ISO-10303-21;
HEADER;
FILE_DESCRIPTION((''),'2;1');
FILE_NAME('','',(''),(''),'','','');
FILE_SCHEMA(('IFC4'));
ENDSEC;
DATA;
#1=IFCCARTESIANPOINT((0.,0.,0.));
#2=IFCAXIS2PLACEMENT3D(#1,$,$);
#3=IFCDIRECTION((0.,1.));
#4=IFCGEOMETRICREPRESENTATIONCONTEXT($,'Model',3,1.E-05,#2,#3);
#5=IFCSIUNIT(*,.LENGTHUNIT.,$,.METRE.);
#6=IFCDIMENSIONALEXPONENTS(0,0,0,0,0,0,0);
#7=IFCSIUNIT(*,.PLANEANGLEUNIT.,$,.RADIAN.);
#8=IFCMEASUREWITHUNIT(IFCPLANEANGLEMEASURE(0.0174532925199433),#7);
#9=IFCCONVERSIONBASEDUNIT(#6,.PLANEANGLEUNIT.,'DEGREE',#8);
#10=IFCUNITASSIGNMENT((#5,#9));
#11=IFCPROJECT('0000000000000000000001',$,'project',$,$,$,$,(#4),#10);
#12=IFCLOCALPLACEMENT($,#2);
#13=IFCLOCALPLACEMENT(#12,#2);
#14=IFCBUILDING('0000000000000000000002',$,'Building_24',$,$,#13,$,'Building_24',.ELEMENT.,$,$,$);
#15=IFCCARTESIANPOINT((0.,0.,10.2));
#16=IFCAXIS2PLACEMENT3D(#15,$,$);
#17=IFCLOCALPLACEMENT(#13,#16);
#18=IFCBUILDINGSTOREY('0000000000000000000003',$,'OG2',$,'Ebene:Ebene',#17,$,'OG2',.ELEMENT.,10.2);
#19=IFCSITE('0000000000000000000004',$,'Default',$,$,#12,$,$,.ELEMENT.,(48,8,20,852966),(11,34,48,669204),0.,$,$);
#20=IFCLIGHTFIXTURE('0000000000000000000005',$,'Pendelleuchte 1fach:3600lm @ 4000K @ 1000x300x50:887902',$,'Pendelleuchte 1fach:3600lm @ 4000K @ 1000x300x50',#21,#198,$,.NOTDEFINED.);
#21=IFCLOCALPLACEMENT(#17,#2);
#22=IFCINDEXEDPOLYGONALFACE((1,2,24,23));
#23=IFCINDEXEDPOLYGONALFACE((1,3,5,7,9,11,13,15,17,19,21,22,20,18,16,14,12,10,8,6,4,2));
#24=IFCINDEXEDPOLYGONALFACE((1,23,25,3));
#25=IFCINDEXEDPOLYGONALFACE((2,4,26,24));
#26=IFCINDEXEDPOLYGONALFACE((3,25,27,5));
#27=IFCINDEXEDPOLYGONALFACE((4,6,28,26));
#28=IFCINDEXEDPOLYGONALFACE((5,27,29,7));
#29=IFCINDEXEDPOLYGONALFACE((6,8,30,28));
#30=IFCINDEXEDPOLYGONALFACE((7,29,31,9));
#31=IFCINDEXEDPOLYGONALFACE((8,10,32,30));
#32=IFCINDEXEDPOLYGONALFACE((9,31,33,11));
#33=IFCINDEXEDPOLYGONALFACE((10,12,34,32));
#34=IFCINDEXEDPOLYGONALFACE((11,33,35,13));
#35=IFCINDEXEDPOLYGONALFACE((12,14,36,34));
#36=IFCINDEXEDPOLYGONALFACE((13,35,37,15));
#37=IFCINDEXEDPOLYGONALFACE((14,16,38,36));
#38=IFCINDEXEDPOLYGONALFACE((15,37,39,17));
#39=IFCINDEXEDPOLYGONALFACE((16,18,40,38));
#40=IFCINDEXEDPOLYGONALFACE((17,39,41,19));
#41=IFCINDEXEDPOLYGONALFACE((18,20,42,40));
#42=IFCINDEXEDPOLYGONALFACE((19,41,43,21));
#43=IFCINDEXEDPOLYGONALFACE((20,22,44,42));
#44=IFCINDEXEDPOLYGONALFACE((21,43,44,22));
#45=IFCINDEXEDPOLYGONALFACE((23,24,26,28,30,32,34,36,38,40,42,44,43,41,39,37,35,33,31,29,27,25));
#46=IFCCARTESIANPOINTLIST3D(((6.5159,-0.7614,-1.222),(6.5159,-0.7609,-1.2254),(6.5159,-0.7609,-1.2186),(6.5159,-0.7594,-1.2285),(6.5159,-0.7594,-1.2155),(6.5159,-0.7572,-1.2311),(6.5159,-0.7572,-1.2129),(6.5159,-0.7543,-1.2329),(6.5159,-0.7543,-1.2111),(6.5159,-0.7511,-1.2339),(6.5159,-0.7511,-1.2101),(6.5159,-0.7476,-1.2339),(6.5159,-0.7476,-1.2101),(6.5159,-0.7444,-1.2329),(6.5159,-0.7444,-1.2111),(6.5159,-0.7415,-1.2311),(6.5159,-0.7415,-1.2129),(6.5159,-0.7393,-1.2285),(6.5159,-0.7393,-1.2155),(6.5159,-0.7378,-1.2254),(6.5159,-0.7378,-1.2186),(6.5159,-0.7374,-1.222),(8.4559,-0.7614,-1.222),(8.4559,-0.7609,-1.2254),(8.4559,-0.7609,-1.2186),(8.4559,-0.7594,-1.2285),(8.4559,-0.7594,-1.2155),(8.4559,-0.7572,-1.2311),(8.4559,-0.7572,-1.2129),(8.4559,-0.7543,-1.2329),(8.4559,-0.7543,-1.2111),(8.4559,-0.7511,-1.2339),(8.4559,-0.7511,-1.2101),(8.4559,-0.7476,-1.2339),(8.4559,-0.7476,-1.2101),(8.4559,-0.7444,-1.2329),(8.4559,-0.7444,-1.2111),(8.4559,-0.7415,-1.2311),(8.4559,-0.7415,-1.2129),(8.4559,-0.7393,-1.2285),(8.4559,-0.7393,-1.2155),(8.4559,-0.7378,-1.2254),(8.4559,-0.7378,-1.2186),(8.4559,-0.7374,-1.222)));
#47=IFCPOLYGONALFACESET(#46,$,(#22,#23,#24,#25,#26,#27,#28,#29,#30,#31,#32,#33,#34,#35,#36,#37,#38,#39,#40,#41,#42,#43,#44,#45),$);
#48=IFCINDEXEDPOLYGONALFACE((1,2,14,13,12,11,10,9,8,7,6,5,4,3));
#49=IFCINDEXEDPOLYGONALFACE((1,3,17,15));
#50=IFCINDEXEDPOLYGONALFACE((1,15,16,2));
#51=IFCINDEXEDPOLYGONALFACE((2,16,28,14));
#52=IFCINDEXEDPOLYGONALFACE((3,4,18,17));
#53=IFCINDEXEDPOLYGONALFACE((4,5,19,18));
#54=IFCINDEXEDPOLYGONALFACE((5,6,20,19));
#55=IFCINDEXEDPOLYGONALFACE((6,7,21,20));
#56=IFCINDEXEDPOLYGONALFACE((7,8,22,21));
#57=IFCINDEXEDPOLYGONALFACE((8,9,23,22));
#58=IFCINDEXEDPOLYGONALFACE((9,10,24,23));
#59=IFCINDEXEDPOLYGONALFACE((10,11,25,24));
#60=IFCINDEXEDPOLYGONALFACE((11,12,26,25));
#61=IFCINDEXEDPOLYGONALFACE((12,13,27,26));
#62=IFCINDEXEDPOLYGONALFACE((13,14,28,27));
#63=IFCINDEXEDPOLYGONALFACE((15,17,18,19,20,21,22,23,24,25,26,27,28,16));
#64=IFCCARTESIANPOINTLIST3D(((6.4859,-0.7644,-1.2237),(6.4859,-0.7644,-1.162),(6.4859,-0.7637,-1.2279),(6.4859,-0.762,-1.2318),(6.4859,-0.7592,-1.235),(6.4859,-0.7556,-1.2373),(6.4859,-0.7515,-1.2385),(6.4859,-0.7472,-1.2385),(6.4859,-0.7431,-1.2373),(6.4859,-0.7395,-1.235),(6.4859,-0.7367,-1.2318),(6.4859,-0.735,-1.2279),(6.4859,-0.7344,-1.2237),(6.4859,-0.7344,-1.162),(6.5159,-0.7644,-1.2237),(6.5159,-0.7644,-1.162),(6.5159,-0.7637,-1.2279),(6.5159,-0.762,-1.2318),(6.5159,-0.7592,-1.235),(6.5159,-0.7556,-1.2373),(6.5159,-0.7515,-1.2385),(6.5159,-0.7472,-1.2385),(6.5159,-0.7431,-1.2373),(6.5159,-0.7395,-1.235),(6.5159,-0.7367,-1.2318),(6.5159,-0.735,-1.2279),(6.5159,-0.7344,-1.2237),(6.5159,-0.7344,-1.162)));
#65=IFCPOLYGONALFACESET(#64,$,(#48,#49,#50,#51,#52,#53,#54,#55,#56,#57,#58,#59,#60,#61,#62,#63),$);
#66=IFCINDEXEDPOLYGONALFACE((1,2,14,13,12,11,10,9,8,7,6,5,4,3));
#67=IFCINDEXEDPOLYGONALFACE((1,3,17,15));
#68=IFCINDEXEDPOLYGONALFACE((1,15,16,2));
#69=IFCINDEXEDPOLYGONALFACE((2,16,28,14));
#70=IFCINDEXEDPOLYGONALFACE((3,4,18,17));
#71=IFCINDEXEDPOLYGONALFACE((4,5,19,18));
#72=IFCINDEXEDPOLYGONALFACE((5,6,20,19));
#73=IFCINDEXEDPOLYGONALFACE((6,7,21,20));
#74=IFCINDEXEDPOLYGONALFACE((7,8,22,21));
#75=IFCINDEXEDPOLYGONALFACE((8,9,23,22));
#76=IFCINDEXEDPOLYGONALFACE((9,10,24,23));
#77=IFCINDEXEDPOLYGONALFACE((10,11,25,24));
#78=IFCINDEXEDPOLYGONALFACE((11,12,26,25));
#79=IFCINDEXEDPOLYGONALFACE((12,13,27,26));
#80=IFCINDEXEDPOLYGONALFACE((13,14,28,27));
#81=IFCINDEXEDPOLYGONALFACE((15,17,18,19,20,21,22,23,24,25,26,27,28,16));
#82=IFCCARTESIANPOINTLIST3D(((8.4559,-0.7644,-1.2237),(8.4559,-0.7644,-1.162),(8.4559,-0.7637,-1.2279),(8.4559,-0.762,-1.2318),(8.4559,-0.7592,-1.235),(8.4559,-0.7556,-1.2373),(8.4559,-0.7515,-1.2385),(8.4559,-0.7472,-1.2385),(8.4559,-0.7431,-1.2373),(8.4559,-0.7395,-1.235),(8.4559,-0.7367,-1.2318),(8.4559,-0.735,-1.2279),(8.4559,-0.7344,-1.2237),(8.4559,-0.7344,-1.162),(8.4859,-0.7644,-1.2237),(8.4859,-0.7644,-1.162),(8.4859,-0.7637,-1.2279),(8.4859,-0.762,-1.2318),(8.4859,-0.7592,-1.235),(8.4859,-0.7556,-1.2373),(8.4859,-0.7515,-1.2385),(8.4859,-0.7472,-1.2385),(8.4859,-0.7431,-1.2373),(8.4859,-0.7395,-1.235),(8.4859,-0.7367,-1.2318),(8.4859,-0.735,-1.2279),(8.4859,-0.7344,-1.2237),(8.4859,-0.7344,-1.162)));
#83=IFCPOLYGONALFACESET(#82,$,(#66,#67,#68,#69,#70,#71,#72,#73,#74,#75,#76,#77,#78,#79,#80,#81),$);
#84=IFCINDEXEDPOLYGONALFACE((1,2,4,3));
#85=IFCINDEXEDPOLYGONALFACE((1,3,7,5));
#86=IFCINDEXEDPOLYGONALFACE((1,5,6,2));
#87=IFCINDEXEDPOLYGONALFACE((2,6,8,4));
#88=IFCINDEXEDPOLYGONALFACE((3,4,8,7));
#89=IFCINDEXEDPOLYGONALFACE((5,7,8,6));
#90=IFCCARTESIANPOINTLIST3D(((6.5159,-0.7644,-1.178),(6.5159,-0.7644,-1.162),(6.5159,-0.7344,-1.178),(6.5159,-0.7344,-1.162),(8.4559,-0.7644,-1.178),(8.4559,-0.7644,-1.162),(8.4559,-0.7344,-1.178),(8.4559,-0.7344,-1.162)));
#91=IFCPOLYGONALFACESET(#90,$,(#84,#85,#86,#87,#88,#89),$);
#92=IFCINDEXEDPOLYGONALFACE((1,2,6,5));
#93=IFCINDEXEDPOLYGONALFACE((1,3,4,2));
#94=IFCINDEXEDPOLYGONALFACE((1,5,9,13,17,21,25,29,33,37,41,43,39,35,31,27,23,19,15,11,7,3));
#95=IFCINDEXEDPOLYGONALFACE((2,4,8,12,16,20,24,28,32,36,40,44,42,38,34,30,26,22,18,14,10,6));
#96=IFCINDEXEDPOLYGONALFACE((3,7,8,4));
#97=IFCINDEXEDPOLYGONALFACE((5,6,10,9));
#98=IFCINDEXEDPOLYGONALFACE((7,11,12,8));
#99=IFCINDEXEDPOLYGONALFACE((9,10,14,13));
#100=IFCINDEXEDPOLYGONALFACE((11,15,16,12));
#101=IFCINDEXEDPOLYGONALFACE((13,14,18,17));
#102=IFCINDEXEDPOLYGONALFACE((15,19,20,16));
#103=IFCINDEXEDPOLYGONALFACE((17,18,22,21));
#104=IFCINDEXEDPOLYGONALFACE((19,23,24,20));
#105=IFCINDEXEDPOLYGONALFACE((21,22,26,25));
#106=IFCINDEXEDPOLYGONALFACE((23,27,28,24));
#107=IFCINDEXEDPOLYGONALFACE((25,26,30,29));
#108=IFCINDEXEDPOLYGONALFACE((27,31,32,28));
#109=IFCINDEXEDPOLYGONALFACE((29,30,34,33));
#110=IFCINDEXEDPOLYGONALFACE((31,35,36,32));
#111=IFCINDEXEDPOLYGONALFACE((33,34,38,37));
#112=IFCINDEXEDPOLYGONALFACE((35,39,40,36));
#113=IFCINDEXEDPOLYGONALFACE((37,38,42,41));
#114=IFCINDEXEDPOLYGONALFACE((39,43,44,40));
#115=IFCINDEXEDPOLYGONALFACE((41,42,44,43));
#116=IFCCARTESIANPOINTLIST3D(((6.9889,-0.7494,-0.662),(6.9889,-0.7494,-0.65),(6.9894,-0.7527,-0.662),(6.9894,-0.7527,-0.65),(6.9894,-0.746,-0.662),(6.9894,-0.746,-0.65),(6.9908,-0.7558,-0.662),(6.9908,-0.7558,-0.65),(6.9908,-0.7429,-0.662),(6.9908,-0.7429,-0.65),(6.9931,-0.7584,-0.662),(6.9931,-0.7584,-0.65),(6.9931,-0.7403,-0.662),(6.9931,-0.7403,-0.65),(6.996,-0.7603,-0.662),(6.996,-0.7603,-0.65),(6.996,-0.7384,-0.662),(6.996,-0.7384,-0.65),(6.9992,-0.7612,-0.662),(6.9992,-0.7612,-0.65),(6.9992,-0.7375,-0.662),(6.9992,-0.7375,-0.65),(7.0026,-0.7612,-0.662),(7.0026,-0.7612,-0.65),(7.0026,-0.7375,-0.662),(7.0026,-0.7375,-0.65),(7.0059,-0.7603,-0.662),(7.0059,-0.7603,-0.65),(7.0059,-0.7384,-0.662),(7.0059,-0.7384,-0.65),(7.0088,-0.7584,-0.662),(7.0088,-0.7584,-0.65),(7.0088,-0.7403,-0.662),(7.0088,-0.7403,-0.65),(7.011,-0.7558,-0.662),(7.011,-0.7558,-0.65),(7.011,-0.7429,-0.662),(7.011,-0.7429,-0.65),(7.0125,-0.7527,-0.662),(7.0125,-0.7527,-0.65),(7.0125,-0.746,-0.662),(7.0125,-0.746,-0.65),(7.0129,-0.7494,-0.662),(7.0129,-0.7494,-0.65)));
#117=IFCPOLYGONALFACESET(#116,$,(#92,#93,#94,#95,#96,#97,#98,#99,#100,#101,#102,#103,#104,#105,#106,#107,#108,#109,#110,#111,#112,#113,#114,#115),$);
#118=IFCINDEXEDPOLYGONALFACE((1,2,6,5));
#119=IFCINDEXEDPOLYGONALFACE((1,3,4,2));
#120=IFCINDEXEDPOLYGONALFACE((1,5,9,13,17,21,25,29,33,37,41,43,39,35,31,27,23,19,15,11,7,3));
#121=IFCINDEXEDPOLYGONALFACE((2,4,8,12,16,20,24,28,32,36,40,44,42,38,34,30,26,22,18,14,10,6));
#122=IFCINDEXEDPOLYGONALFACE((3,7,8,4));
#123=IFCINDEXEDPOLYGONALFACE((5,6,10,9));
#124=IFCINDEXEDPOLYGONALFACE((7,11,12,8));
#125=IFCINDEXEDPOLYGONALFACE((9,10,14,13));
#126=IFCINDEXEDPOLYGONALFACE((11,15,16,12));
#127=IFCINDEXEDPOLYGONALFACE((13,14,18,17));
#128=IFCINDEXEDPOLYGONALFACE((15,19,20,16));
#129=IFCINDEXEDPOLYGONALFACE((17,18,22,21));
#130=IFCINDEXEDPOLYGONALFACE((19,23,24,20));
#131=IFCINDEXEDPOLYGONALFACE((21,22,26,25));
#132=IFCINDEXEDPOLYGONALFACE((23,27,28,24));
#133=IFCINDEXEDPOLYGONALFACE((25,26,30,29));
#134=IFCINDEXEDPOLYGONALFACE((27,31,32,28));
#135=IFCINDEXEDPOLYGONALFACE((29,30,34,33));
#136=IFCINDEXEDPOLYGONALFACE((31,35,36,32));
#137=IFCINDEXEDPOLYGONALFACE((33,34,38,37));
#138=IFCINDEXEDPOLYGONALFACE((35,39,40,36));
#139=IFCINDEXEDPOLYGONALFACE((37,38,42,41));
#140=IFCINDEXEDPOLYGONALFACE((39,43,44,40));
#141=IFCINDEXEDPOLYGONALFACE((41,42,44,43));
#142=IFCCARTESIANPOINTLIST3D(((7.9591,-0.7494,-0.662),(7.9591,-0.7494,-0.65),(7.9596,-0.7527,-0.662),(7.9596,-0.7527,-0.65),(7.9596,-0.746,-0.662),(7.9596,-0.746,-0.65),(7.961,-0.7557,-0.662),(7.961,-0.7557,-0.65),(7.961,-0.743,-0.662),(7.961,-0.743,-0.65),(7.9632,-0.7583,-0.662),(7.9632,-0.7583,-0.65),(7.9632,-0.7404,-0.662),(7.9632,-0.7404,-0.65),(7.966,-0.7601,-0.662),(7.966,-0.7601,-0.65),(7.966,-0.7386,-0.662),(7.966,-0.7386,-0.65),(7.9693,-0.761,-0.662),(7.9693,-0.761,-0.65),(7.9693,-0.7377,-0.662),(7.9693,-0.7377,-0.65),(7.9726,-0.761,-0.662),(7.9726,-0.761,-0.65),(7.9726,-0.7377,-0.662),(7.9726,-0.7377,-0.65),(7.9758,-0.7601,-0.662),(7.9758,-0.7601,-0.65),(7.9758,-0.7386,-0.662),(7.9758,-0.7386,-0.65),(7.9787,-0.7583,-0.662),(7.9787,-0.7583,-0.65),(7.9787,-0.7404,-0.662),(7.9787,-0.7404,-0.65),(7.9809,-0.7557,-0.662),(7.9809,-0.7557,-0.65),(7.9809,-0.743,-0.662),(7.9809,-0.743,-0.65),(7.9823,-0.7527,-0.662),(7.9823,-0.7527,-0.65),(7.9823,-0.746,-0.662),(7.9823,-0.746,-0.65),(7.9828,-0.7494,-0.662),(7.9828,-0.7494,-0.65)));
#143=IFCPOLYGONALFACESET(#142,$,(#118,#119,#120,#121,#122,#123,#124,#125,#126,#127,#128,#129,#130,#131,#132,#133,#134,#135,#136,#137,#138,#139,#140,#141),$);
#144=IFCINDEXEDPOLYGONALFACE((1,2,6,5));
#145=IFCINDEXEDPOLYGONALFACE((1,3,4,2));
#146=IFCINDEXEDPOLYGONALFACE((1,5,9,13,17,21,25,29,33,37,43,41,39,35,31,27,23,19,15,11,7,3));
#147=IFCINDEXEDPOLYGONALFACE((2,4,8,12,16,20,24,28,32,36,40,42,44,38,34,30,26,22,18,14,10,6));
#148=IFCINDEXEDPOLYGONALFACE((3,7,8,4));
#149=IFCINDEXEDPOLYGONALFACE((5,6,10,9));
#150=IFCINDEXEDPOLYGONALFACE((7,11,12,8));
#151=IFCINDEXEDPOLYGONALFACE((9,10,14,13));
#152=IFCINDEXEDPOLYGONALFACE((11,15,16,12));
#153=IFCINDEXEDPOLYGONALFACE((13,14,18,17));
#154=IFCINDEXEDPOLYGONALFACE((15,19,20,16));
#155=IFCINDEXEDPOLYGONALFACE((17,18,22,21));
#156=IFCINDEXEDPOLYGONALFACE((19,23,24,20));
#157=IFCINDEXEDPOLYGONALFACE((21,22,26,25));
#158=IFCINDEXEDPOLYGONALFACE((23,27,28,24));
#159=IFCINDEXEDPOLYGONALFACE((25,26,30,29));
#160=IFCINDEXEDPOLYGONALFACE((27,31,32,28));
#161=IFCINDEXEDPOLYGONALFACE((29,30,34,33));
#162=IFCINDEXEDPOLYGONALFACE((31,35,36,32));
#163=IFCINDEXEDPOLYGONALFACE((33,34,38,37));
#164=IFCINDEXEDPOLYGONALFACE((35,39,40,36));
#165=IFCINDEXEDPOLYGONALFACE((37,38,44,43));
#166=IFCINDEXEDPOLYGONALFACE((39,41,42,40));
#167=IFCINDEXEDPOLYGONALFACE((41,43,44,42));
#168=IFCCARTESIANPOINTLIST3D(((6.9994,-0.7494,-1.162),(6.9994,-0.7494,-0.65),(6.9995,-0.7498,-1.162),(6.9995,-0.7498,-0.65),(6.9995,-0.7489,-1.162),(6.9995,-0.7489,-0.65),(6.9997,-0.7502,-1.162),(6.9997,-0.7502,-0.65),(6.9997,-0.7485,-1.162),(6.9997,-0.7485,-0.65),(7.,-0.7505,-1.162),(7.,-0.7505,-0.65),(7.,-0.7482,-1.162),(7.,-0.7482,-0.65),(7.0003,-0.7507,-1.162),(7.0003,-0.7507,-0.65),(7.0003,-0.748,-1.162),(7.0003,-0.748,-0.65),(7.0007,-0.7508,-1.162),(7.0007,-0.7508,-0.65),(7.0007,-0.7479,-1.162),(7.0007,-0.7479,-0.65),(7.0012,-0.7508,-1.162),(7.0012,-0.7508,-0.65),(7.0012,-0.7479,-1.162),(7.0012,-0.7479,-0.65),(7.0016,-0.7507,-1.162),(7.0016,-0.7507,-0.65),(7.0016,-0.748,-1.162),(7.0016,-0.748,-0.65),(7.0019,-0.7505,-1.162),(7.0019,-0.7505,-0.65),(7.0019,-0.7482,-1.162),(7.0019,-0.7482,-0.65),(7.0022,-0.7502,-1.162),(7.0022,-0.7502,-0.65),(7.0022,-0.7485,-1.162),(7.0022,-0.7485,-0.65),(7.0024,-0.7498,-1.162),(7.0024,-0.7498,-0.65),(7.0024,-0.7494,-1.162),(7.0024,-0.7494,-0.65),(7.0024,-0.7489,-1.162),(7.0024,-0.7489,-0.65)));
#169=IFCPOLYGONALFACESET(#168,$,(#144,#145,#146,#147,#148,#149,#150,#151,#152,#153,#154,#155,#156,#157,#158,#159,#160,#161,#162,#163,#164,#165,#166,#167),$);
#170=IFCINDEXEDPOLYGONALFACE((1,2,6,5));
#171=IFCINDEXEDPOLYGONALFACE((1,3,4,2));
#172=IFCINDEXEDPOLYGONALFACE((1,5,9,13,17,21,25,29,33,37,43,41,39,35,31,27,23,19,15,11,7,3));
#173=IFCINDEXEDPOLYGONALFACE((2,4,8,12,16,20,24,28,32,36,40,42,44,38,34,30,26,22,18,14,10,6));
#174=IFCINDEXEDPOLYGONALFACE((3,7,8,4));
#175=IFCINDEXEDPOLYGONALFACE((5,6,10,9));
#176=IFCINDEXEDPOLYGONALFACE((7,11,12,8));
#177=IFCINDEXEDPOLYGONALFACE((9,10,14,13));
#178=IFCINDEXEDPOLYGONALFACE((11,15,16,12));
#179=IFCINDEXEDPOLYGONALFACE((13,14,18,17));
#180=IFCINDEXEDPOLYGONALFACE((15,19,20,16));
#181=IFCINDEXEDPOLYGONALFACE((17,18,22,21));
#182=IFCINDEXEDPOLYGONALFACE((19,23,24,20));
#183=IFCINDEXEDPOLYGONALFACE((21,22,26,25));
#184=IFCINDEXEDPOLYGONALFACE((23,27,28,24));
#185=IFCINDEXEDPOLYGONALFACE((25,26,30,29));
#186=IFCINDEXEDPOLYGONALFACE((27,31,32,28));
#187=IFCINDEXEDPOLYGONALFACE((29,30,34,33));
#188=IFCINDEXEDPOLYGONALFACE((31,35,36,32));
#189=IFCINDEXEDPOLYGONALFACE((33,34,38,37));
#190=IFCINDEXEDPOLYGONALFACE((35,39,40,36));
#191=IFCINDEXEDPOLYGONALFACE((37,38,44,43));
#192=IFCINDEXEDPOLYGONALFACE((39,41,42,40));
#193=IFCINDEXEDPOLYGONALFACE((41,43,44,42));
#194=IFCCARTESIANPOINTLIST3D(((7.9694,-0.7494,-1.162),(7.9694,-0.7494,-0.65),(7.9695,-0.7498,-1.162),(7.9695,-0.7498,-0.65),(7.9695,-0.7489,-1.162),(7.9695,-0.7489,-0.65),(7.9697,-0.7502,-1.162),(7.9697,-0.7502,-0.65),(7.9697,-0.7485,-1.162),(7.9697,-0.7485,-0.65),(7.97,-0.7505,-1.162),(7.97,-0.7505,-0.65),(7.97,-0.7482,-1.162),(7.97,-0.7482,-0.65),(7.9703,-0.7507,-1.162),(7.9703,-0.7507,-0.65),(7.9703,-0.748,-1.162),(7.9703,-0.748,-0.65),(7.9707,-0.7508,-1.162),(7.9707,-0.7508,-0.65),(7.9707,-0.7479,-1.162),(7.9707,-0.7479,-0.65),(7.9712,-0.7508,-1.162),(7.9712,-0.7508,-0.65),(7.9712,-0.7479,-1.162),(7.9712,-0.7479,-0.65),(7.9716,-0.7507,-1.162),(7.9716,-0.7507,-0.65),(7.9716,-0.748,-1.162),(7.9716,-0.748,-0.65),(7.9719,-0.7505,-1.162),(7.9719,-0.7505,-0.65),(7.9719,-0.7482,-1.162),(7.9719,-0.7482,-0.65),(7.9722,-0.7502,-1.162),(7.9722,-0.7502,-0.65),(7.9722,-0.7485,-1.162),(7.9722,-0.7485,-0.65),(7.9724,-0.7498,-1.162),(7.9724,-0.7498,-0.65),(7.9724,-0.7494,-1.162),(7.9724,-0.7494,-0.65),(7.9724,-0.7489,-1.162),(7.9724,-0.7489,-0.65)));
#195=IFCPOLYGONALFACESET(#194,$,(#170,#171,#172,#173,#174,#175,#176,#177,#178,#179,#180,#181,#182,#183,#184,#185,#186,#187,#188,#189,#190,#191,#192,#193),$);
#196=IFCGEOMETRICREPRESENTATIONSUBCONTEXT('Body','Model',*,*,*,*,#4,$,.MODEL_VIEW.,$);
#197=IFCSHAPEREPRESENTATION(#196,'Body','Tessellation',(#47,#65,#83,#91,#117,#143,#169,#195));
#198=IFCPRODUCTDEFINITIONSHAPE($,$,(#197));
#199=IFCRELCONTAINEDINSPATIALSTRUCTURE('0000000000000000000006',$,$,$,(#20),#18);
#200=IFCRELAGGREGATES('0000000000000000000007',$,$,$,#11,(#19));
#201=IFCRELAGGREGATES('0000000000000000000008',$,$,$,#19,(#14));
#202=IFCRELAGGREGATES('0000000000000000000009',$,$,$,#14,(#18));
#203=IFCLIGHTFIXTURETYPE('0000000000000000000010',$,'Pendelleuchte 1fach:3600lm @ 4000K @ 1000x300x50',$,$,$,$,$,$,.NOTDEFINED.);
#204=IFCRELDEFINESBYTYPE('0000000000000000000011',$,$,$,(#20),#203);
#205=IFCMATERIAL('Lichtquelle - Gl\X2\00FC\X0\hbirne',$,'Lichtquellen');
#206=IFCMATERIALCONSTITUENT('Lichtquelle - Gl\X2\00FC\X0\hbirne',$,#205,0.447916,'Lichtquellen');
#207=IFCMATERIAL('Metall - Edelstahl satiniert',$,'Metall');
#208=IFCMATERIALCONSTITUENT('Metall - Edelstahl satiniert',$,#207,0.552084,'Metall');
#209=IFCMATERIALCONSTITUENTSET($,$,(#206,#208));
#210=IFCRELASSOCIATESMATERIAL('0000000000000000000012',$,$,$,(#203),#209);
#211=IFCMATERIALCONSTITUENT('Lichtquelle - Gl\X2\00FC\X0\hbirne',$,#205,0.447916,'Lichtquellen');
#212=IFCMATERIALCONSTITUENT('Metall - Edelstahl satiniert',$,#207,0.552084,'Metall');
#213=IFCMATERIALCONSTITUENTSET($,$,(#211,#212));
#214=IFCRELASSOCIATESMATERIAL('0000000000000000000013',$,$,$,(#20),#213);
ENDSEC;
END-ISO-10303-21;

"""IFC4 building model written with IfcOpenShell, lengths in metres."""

from ifc_helpers import new_model, entity, si_unit, converted_unit, direction, frame, origin, place, context, subcontext, project, spatial, line, arc, indexed_curve, outline, extrude, source, transform, mapped, material, constituent, constituent_set, type_object, type_shapes, element, save


model = new_model("IFC4")

# Units and contexts
model_context = context("Model", 3, precision=1e-05, world=origin(), true_north=direction((0.0, 1.0)))
body_context = subcontext(model_context, "Body", "Model", "MODEL_VIEW")
ifc_project = project(units=[si_unit("LENGTHUNIT", "METRE"), converted_unit("PLANEANGLEUNIT", "DEGREE", entity("IfcPlaneAngleMeasure", 0.0174532925199433), si_unit("PLANEANGLEUNIT", "RADIAN"), dimensions=[0, 0, 0, 0, 0, 0, 0])], contexts=[model_context])

# Site, building, storey
site_placement = place(None, origin())
site = spatial("IfcSite", under=ifc_project, at=site_placement, Name="Default", CompositionType="ELEMENT", RefLatitude=(48, 8, 20, 852966), RefLongitude=(11, 34, 48, 669204), RefElevation=0.0)
building_placement = place(site_placement, origin())
building = spatial("IfcBuilding", under=site, at=building_placement, Name="Building_24", LongName="Building_24", CompositionType="ELEMENT")
storey_placement = place(building_placement, frame((0.0, 0.0, 10.2)))
storey = spatial("IfcBuildingStorey", under=building, at=storey_placement, Name="OG2", ObjectType="Ebene:Ebene", LongName="OG2", CompositionType="ELEMENT", Elevation=10.2)

# Light fixture
ifc_material_1 = material(Name="Lichtquelle - Glühbirne", Category="Lichtquellen")
ifc_material_2 = material(Name="Metall - Edelstahl satiniert", Category="Metall")
ifc_constituent_1 = constituent(ifc_material_1, Name="Lichtquelle - Glühbirne", Category="Lichtquellen", fraction=0.447916)
ifc_constituent_2 = constituent(ifc_material_2, Name="Metall - Edelstahl satiniert", Category="Metall", fraction=0.552084)
ifc_constituent_set_1 = constituent_set(constituents=[ifc_constituent_1, ifc_constituent_2])
ifc_constituent_3 = constituent(ifc_material_1, Name="Lichtquelle - Glühbirne", Category="Lichtquellen", fraction=0.447916)
ifc_constituent_4 = constituent(ifc_material_2, Name="Metall - Edelstahl satiniert", Category="Metall", fraction=0.552084)
ifc_constituent_set_2 = constituent_set(constituents=[ifc_constituent_3, ifc_constituent_4])
light_fixture_type_1 = type_object("IfcLightFixtureType", Name="Pendelleuchte 1fach:3600lm @ 4000K @ 1000x300x50", PredefinedType="NOTDEFINED", material=ifc_constituent_set_2)
shared_shape_1 = source(origin(), body_context, "Body", "SweptSolid", [
    extrude(outline(indexed_curve([(-0.012, 0.0), (0.0, -0.012), (0.012, 0.0), (0.0, 0.012)], segments=[arc(1, 2, 3), arc(3, 4, 1)], self_intersect=False)), frame((-0.97, 0.0, -0.572), z_axis=(1.0, 0.0, 0.0), x_axis=(0.0, -1.0, 0.0)), (0.0, 0.0, 1.0), 1.94),
    extrude(outline(indexed_curve([(0.015, 0.0308), (0.0, 0.0458), (-0.015, 0.0308), (-0.015, -0.0308), (0.015, -0.0308)], segments=[arc(1, 2, 3), line(3, 4, 5, 1)], self_intersect=False)), frame((0.97, 0.0, -0.5428), z_axis=(1.0, 0.0, 0.0), x_axis=(0.0, -1.0, 0.0)), (0.0, 0.0, 1.0), 0.03),
    extrude(outline(indexed_curve([(0.015, 0.0308), (0.0, 0.0458), (-0.015, 0.0308), (-0.015, -0.0308), (0.015, -0.0308)], segments=[arc(1, 2, 3), line(3, 4, 5, 1)], self_intersect=False)), frame((-1.0, 0.0, -0.5428), z_axis=(1.0, 0.0, 0.0), x_axis=(0.0, -1.0, 0.0)), (0.0, 0.0, 1.0), 0.03),
    extrude(outline(indexed_curve([(-0.015, -0.97), (0.015, -0.97), (0.015, 0.97), (-0.015, 0.97), (-0.015, -0.97)], self_intersect=False)), frame((0.0, 0.0, -0.528), z_axis=(0.0, 0.0, 1.0), x_axis=(0.0, 1.0, 0.0)), (0.0, 0.0, 1.0), 0.016),
    extrude(outline(indexed_curve([(-0.012, 0.0), (0.0, -0.012), (0.012, 0.0), (0.0, 0.012)], segments=[arc(1, 2, 3), arc(3, 4, 1)], self_intersect=False)), frame((0.485, 0.0, -0.012)), (0.0, 0.0, 1.0), 0.012),
    extrude(outline(indexed_curve([(-0.0118, 0.0), (0.0, -0.0118), (0.0118, 0.0), (0.0, 0.0118)], segments=[arc(1, 2, 3), arc(3, 4, 1)], self_intersect=False)), frame((-0.485, 0.0, -0.012)), (0.0, 0.0, 1.0), 0.012),
    extrude(outline(indexed_curve([(-0.0015, 0.0), (0.0, -0.0015), (0.0015, 0.0), (0.0, 0.0015)], segments=[arc(1, 2, 3), arc(3, 4, 1)], self_intersect=False)), frame((0.485, 0.0, -0.512)), (0.0, 0.0, 1.0), 0.512),
    extrude(outline(indexed_curve([(-0.0015, 0.0), (0.0, -0.0015), (0.0015, 0.0), (0.0, 0.0015)], segments=[arc(1, 2, 3), arc(3, 4, 1)], self_intersect=False)), frame((-0.485, 0.0, -0.512)), (0.0, 0.0, 1.0), 0.512),
])
type_shapes(light_fixture_type_1, [shared_shape_1])
light_fixture_1_placement = place(storey_placement, frame((7.4859, -0.7494, -0.65), z_axis=(0.0, 0.0, 1.0), x_axis=(-1.0, 0.0, 0.0)))
element("IfcLightFixture", 1, at=light_fixture_1_placement, inside=storey, type_object=light_fixture_type_1, material=ifc_constituent_set_1, Name="Pendelleuchte 1fach:3600lm @ 4000K @ 1000x300x50:887902", ObjectType="Pendelleuchte 1fach:3600lm @ 4000K @ 1000x300x50", PredefinedType="NOTDEFINED", context=body_context, shape_type="MappedRepresentation", body=[
    mapped(shared_shape_1, transform((0.0, 0.0, 0.0), scale=1.0)),
])

save(model, "model.ifc")
